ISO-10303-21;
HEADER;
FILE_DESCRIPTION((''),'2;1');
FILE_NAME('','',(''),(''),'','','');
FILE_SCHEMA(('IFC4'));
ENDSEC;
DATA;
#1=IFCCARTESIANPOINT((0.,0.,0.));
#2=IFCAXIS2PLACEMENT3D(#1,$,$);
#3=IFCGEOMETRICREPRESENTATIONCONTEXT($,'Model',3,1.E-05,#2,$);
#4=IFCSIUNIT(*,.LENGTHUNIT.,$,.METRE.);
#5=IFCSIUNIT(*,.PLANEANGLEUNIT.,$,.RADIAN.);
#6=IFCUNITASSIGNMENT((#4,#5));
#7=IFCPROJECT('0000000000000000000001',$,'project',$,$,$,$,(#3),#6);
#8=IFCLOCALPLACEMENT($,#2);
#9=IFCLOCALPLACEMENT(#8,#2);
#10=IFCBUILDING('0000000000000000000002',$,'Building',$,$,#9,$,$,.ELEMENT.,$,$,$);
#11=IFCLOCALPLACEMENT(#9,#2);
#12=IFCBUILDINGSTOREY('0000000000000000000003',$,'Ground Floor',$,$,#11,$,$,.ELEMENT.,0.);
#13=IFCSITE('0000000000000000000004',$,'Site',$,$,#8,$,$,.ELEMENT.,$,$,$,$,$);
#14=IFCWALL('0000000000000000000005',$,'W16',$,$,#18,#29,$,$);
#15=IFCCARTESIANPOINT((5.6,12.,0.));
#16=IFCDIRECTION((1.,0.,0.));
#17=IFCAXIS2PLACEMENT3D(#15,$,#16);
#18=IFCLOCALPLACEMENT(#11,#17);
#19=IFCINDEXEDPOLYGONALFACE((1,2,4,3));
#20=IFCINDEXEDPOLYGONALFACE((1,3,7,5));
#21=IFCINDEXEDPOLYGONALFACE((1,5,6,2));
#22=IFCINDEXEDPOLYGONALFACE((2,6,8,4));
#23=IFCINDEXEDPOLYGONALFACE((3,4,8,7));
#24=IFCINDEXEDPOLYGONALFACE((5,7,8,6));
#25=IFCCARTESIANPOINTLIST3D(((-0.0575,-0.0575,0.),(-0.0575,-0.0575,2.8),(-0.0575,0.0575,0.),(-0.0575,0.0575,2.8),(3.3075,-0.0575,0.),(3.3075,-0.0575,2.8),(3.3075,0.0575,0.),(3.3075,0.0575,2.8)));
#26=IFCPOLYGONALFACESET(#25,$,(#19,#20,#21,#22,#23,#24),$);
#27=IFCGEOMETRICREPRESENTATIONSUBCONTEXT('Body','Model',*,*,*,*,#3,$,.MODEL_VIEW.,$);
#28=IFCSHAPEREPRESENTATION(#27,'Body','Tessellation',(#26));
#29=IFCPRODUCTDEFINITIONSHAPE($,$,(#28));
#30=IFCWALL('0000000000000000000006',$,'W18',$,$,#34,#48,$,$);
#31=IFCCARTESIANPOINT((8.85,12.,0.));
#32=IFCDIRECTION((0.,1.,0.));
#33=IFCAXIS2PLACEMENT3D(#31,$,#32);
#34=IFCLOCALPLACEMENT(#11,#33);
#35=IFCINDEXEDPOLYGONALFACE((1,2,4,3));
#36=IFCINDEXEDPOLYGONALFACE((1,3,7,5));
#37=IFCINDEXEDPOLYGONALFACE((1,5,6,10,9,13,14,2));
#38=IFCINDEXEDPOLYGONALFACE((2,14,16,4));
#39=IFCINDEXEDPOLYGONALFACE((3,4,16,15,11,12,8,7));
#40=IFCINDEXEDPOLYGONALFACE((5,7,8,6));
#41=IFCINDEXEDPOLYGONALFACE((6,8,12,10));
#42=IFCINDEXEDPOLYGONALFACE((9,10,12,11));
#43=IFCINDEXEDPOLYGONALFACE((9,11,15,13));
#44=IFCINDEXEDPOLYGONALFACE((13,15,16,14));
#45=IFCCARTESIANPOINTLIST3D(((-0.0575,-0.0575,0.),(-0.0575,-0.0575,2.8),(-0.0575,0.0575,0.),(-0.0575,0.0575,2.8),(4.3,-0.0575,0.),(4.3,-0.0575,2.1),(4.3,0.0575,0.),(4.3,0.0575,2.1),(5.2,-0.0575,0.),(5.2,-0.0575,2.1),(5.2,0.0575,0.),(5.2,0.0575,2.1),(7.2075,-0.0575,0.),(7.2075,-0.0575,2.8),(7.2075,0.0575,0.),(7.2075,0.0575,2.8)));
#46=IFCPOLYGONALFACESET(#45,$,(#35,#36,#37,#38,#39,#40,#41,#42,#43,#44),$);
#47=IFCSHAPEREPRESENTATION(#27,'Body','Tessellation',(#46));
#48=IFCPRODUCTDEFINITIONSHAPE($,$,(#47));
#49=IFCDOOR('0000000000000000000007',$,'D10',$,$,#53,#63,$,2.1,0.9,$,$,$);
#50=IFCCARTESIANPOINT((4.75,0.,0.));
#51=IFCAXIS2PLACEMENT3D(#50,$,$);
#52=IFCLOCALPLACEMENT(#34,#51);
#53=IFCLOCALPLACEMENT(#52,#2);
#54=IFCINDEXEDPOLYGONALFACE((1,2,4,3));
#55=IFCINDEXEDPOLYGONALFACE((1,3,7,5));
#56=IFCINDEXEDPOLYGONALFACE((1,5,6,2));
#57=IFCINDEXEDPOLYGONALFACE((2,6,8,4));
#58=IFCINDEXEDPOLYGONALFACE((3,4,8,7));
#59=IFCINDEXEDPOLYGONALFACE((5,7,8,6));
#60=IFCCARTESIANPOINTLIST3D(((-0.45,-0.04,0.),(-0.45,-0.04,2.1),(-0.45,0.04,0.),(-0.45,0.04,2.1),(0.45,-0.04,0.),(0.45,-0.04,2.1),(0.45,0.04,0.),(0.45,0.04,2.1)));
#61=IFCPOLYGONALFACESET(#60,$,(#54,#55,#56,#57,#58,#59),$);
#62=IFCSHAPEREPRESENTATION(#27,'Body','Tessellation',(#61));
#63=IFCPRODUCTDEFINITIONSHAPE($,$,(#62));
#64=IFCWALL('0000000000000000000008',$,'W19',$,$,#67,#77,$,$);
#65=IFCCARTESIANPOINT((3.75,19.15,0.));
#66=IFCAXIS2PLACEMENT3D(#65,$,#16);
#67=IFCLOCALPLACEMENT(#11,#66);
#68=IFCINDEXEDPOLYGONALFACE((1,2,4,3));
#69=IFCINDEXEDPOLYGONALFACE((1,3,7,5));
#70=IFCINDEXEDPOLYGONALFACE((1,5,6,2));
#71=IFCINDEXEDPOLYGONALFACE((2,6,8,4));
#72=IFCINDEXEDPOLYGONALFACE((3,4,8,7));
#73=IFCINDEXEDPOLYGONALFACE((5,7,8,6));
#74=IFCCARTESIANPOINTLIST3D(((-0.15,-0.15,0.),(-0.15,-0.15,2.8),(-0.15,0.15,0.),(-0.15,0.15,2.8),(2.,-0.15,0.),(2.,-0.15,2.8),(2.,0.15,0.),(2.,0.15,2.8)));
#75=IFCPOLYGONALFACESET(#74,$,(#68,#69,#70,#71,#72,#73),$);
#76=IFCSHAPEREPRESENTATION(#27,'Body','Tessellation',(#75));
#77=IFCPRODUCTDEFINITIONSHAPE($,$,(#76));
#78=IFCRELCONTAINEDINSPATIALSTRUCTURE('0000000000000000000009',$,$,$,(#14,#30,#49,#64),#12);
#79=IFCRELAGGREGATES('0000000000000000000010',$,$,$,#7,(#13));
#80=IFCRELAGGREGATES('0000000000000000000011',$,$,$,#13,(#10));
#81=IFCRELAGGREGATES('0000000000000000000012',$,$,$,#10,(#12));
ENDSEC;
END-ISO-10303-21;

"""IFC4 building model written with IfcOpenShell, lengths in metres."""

from ifc_helpers import new_model, si_unit, frame, frame_2d, origin, origin_2d, place, context, subcontext, project, spatial, rectangle, extrude, element, fill, save


model = new_model("IFC4")

# Units and contexts
model_context = context("Model", 3, precision=1e-05, world=origin())
body_context = subcontext(model_context, "Body", "Model", "MODEL_VIEW")
ifc_project = project(units=[si_unit("LENGTHUNIT", "METRE"), si_unit("PLANEANGLEUNIT", "RADIAN")], contexts=[model_context])

# Site, building, storey
site_placement = place(None, origin())
site = spatial("IfcSite", under=ifc_project, at=site_placement, Name="Site", CompositionType="ELEMENT")
building_placement = place(site_placement, origin())
building = spatial("IfcBuilding", under=site, at=building_placement, Name="Building", CompositionType="ELEMENT")
storey_placement = place(building_placement, origin())
storey = spatial("IfcBuildingStorey", under=building, at=storey_placement, Name="Ground Floor", CompositionType="ELEMENT", Elevation=0.0)

# Wall
wall_1_placement = place(storey_placement, frame((5.6, 12.0, 0.0), x_axis=(1.0, 0.0, 0.0)))
element("IfcWall", 1, at=wall_1_placement, inside=storey, Name="W16", context=body_context, shape_type="SweptSolid", body=[
    extrude(rectangle(XDim=3.365, YDim=0.115, at=frame_2d((1.625, 0.0))), origin(), (0.0, 0.0, 1.0), 2.8),
])

# Wall, opening, door
wall_2_placement = place(storey_placement, frame((8.85, 12.0, 0.0), x_axis=(0.0, 1.0, 0.0)))
wall_2 = element("IfcWall", 2, at=wall_2_placement, inside=storey, Name="W18", context=body_context, shape_type="SweptSolid", body=[
    extrude(rectangle(XDim=7.265, YDim=0.115, at=frame_2d((3.575, 0.0))), origin(), (0.0, 0.0, 1.0), 2.8),
])
opening_1_placement = place(wall_2_placement, frame((4.75, 0.0, 0.0)))
opening_1 = element("IfcOpeningElement", 3, at=opening_1_placement, cuts=wall_2, context=body_context, shape_type="SweptSolid", body=[
    extrude(rectangle(XDim=0.9, YDim=0.215, at=origin_2d()), origin(), (0.0, 0.0, 1.0), 2.1),
])
door_1_placement = place(opening_1_placement, origin())
door_1 = element("IfcDoor", 4, at=door_1_placement, inside=storey, Name="D10", OverallHeight=2.1, OverallWidth=0.9, context=body_context, shape_type="SweptSolid", body=[
    extrude(rectangle(XDim=0.9, YDim=0.08, at=origin_2d()), origin(), (0.0, 0.0, 1.0), 2.1),
])
fill(opening_1, door_1)

# Wall
wall_3_placement = place(storey_placement, frame((3.75, 19.15, 0.0), x_axis=(1.0, 0.0, 0.0)))
element("IfcWall", 5, at=wall_3_placement, inside=storey, Name="W19", context=body_context, shape_type="SweptSolid", body=[
    extrude(rectangle(XDim=2.15, YDim=0.3, at=frame_2d((0.925, 0.0))), origin(), (0.0, 0.0, 1.0), 2.8),
])

save(model, "model.ifc")
